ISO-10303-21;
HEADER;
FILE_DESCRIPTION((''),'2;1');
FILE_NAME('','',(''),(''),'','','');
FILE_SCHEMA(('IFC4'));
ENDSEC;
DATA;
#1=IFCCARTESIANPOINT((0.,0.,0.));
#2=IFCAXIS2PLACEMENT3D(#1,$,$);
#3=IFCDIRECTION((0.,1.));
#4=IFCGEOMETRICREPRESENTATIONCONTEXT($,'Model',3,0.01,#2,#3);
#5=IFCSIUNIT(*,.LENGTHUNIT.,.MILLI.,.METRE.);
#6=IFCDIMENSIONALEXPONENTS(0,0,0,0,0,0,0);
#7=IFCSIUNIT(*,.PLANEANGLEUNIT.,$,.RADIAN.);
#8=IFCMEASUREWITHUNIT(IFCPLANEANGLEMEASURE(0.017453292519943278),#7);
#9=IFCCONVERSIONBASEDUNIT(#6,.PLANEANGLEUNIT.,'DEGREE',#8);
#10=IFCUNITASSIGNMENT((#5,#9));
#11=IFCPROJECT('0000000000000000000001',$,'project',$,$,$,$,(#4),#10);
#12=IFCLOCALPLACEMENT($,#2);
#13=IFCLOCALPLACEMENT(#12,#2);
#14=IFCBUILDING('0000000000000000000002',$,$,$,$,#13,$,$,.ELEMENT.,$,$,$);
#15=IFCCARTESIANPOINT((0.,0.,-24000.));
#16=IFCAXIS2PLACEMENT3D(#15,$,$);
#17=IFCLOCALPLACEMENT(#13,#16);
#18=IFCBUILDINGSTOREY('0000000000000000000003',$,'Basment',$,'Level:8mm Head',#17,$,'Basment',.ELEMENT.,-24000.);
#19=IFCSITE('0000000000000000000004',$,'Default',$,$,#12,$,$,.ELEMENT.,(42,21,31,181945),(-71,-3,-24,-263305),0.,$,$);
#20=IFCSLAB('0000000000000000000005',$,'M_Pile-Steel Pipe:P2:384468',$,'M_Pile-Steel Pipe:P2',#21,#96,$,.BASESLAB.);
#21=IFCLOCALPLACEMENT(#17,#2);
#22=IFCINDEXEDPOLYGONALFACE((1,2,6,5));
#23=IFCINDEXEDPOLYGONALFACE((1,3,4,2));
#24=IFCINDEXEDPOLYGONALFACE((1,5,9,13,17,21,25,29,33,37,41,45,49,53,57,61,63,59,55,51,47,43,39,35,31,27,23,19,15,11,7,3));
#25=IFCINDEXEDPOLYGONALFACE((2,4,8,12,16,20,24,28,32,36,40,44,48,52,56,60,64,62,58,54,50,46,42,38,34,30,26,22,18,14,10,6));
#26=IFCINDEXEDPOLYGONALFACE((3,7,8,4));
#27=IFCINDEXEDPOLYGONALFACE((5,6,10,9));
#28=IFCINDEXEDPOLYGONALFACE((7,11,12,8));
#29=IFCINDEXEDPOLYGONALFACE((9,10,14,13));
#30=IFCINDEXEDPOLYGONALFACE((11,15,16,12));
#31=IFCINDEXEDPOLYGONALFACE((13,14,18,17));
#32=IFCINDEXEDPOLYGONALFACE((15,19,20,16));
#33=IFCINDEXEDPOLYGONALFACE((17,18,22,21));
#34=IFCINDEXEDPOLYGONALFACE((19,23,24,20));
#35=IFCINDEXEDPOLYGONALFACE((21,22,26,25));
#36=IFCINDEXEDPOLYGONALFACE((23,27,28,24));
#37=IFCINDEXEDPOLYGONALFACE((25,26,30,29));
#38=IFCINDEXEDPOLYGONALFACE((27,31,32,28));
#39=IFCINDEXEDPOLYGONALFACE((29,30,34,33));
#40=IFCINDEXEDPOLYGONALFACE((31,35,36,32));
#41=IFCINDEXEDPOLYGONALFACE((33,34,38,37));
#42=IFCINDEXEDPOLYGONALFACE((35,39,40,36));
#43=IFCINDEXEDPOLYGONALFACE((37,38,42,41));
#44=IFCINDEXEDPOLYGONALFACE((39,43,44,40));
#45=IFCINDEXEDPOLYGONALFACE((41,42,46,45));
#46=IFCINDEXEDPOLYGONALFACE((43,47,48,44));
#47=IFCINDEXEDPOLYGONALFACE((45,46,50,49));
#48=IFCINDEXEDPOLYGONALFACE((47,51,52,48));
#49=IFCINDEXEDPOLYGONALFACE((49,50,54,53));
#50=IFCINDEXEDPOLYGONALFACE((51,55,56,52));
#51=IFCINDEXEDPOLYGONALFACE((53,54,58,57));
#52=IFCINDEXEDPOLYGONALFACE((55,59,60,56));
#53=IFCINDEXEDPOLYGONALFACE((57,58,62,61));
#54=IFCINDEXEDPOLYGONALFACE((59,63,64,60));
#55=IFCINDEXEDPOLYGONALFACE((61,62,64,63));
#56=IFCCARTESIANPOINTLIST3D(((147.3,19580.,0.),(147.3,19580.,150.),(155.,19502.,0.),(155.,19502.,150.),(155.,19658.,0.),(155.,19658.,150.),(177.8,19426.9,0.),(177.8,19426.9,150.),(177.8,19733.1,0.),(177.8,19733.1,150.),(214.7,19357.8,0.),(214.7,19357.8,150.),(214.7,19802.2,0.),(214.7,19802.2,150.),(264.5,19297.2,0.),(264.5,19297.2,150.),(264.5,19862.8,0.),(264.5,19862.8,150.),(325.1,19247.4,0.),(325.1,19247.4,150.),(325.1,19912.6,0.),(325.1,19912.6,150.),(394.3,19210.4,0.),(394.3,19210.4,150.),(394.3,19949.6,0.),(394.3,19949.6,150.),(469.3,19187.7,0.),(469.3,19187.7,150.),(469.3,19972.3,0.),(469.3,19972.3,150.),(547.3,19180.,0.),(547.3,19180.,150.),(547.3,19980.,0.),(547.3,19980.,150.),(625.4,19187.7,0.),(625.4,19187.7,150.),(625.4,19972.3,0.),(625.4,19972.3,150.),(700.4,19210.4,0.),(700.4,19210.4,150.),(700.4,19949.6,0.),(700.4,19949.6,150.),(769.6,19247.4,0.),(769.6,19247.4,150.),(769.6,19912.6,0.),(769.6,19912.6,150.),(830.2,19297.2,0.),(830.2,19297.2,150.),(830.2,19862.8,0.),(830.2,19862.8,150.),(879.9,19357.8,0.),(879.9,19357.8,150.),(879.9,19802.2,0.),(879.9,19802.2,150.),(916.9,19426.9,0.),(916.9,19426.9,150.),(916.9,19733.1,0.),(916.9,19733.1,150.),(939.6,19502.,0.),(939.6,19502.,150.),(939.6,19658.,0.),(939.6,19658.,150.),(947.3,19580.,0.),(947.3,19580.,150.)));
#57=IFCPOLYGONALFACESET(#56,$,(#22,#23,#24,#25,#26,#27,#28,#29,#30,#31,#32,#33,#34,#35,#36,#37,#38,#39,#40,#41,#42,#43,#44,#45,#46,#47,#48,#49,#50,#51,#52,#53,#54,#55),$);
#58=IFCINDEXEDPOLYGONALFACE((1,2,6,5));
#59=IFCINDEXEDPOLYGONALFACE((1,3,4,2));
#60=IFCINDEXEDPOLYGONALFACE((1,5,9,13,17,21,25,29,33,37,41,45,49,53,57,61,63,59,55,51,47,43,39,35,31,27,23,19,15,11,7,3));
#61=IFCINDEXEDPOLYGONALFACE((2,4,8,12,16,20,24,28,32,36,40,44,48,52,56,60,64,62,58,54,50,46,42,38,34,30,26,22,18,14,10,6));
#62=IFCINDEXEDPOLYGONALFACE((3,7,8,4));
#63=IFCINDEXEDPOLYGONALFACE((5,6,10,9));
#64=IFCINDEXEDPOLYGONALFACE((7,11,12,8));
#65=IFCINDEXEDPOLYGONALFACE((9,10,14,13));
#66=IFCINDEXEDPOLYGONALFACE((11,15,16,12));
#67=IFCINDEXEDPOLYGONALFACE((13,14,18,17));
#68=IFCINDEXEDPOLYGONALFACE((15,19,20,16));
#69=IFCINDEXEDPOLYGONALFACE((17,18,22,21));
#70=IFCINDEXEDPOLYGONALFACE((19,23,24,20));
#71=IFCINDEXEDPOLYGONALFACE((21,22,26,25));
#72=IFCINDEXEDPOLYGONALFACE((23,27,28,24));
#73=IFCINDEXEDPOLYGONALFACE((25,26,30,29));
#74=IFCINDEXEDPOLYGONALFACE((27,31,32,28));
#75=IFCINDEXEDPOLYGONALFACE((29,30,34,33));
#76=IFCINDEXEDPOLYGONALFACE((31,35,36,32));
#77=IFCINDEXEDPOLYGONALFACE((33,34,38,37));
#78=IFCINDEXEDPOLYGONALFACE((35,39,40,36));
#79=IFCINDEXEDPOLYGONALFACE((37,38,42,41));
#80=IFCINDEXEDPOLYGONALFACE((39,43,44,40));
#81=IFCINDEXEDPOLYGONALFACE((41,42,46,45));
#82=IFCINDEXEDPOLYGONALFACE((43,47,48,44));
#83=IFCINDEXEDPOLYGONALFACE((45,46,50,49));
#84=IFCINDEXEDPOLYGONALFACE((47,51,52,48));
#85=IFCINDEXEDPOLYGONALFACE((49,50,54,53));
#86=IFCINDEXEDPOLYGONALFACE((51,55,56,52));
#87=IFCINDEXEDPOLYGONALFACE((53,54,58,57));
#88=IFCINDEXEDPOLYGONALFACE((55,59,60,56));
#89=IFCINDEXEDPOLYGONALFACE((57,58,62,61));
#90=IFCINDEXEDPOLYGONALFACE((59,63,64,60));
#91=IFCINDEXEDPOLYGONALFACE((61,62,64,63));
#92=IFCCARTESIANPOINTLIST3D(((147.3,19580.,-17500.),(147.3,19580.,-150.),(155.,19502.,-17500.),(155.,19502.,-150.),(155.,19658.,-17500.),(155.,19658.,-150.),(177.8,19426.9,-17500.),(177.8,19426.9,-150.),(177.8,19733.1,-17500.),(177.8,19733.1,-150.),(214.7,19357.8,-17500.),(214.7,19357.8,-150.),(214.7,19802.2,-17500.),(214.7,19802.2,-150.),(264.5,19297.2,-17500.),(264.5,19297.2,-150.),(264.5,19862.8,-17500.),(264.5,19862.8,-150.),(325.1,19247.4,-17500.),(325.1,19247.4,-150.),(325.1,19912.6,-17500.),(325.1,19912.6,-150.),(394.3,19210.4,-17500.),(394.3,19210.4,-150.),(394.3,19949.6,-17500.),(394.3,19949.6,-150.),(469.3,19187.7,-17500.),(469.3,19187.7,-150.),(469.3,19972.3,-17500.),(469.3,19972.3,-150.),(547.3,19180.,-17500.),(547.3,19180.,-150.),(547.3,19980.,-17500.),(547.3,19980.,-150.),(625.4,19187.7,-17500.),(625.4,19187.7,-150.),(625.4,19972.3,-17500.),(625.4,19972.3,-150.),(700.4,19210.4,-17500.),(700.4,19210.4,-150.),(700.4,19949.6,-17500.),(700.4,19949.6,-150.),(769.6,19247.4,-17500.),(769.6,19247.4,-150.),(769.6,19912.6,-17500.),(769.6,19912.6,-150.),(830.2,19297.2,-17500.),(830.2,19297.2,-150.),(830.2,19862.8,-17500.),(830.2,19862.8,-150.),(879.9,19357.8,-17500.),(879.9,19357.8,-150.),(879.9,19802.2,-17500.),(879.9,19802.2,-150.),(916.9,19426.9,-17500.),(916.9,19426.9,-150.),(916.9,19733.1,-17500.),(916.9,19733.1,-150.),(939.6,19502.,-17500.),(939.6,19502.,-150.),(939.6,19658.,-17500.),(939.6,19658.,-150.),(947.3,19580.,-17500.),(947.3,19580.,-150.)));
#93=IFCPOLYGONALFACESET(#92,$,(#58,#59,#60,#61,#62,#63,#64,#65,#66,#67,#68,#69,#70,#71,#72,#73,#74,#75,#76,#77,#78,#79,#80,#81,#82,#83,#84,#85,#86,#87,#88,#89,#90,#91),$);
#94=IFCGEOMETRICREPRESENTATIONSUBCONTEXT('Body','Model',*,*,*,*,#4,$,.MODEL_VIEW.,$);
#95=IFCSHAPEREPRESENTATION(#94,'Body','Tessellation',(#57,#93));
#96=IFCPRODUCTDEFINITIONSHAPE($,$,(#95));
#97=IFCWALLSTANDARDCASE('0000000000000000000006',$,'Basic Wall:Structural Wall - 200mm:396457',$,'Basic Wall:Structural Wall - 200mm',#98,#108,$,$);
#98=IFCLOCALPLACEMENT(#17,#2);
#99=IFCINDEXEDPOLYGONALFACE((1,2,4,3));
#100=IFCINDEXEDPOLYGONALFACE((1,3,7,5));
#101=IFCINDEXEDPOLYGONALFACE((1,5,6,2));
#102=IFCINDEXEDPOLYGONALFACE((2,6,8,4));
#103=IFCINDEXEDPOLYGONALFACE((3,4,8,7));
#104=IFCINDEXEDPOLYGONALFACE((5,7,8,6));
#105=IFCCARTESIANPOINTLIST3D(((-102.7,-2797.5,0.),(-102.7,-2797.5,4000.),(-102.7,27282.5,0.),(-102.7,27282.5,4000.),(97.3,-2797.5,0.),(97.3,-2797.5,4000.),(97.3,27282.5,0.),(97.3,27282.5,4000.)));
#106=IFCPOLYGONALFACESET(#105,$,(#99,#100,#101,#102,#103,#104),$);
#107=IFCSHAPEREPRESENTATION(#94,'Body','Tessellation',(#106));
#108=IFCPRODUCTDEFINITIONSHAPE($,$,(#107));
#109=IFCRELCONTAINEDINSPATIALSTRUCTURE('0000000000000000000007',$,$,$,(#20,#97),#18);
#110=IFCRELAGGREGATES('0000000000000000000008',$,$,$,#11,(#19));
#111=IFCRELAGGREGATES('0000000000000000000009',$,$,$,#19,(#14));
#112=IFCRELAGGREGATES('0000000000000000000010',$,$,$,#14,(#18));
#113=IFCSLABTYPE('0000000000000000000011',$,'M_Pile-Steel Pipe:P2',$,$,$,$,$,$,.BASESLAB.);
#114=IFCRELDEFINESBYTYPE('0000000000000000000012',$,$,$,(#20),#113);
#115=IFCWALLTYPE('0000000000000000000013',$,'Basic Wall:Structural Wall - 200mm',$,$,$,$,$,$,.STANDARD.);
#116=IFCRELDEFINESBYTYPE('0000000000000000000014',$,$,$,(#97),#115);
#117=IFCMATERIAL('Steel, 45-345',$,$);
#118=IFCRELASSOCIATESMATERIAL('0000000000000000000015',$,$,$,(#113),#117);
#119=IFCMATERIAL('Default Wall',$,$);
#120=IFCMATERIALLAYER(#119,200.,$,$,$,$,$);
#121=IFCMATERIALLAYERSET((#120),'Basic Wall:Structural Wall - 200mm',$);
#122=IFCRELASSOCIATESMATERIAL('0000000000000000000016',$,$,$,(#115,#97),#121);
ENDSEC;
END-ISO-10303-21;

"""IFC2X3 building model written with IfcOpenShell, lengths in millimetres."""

from ifc_helpers import new_model, entity, si_unit, converted_unit, direction, frame, frame_2d, origin, place, context, subcontext, project, spatial, rectangle, circle, extrude, material, layer, layer_set, layer_usage, type_object, element, save


model = new_model("IFC2X3")

# Units and contexts
model_context = context("Model", 3, precision=0.01, world=origin(), true_north=direction((0.0, 1.0)))
body_context = subcontext(model_context, "Body", "Model", "MODEL_VIEW")
ifc_project = project(units=[si_unit("LENGTHUNIT", "METRE", prefix="MILLI"), converted_unit("PLANEANGLEUNIT", "DEGREE", entity("IfcPlaneAngleMeasure", 0.017453292519943278), si_unit("PLANEANGLEUNIT", "RADIAN"), dimensions=[0, 0, 0, 0, 0, 0, 0])], contexts=[model_context])

# Site, building, storey
site_placement = place(None, origin())
site = spatial("IfcSite", under=ifc_project, at=site_placement, Name="Default", CompositionType="ELEMENT", RefLatitude=(42, 21, 31, 181945), RefLongitude=(-71, -3, -24, -263305), RefElevation=0.0)
building_placement = place(site_placement, origin())
building = spatial("IfcBuilding", under=site, at=building_placement, CompositionType="ELEMENT")
storey_placement = place(building_placement, frame((0.0, 0.0, -24000.0)))
storey = spatial("IfcBuildingStorey", under=building, at=storey_placement, Name="Basment", ObjectType="Level:8mm Head", LongName="Basment", CompositionType="ELEMENT", Elevation=-24000.0)

# Slab
ifc_material_1 = material(Name="Steel, 45-345")
slab_type_1 = type_object("IfcSlabType", Name="M_Pile-Steel Pipe:P2", PredefinedType="BASESLAB", material=ifc_material_1)
slab_1_placement = place(storey_placement, origin())
element("IfcSlab", 1, at=slab_1_placement, inside=storey, type_object=slab_type_1, Name="M_Pile-Steel Pipe:P2:384468", ObjectType="M_Pile-Steel Pipe:P2", PredefinedType="BASESLAB", context=body_context, shape_type="SweptSolid", body=[
    extrude(circle(Radius=400.0, at=frame_2d((0.0, 0.0), x_axis=(1.0, 0.0))), frame((547.3, 19580.0, 0.0), z_axis=(0.0, 0.0, 1.0), x_axis=(0.0, 1.0, 0.0)), (0.0, 0.0, 1.0), 150.0),
    extrude(circle(Radius=400.0, at=frame_2d((0.0, 0.0), x_axis=(1.0, 0.0))), frame((547.3, 19580.0, -17500.0), z_axis=(0.0, 0.0, 1.0), x_axis=(0.0, 1.0, 0.0)), (0.0, 0.0, 1.0), 17350.0),
])

# Wall
ifc_material_2 = material(Name="Default Wall")
ifc_layer = layer(ifc_material_2, 200.0)
ifc_layer_set = layer_set([ifc_layer], Name="Basic Wall:Structural Wall - 200mm")
ifc_layer_usage = layer_usage(ifc_layer_set, "AXIS2", "NEGATIVE", 100.0)
wall_type = type_object("IfcWallType", Name="Basic Wall:Structural Wall - 200mm", PredefinedType="STANDARD", material=ifc_layer_set)
wall_placement = place(storey_placement, frame((-2.7, -2797.5, 0.0), z_axis=(0.0, 0.0, 1.0), x_axis=(0.0, 1.0, 0.0)))
element("IfcWallStandardCase", 2, at=wall_placement, inside=storey, type_object=wall_type, material=ifc_layer_usage, Name="Basic Wall:Structural Wall - 200mm:396457", ObjectType="Basic Wall:Structural Wall - 200mm", context=body_context, shape_type="SweptSolid", body=[
    extrude(rectangle(XDim=30080.0, YDim=200.0, at=frame_2d((15040.0, 0.0), x_axis=(-1.0, 0.0))), origin(), (0.0, 0.0, 1.0), 4000.0),
])

save(model, "model.ifc")
